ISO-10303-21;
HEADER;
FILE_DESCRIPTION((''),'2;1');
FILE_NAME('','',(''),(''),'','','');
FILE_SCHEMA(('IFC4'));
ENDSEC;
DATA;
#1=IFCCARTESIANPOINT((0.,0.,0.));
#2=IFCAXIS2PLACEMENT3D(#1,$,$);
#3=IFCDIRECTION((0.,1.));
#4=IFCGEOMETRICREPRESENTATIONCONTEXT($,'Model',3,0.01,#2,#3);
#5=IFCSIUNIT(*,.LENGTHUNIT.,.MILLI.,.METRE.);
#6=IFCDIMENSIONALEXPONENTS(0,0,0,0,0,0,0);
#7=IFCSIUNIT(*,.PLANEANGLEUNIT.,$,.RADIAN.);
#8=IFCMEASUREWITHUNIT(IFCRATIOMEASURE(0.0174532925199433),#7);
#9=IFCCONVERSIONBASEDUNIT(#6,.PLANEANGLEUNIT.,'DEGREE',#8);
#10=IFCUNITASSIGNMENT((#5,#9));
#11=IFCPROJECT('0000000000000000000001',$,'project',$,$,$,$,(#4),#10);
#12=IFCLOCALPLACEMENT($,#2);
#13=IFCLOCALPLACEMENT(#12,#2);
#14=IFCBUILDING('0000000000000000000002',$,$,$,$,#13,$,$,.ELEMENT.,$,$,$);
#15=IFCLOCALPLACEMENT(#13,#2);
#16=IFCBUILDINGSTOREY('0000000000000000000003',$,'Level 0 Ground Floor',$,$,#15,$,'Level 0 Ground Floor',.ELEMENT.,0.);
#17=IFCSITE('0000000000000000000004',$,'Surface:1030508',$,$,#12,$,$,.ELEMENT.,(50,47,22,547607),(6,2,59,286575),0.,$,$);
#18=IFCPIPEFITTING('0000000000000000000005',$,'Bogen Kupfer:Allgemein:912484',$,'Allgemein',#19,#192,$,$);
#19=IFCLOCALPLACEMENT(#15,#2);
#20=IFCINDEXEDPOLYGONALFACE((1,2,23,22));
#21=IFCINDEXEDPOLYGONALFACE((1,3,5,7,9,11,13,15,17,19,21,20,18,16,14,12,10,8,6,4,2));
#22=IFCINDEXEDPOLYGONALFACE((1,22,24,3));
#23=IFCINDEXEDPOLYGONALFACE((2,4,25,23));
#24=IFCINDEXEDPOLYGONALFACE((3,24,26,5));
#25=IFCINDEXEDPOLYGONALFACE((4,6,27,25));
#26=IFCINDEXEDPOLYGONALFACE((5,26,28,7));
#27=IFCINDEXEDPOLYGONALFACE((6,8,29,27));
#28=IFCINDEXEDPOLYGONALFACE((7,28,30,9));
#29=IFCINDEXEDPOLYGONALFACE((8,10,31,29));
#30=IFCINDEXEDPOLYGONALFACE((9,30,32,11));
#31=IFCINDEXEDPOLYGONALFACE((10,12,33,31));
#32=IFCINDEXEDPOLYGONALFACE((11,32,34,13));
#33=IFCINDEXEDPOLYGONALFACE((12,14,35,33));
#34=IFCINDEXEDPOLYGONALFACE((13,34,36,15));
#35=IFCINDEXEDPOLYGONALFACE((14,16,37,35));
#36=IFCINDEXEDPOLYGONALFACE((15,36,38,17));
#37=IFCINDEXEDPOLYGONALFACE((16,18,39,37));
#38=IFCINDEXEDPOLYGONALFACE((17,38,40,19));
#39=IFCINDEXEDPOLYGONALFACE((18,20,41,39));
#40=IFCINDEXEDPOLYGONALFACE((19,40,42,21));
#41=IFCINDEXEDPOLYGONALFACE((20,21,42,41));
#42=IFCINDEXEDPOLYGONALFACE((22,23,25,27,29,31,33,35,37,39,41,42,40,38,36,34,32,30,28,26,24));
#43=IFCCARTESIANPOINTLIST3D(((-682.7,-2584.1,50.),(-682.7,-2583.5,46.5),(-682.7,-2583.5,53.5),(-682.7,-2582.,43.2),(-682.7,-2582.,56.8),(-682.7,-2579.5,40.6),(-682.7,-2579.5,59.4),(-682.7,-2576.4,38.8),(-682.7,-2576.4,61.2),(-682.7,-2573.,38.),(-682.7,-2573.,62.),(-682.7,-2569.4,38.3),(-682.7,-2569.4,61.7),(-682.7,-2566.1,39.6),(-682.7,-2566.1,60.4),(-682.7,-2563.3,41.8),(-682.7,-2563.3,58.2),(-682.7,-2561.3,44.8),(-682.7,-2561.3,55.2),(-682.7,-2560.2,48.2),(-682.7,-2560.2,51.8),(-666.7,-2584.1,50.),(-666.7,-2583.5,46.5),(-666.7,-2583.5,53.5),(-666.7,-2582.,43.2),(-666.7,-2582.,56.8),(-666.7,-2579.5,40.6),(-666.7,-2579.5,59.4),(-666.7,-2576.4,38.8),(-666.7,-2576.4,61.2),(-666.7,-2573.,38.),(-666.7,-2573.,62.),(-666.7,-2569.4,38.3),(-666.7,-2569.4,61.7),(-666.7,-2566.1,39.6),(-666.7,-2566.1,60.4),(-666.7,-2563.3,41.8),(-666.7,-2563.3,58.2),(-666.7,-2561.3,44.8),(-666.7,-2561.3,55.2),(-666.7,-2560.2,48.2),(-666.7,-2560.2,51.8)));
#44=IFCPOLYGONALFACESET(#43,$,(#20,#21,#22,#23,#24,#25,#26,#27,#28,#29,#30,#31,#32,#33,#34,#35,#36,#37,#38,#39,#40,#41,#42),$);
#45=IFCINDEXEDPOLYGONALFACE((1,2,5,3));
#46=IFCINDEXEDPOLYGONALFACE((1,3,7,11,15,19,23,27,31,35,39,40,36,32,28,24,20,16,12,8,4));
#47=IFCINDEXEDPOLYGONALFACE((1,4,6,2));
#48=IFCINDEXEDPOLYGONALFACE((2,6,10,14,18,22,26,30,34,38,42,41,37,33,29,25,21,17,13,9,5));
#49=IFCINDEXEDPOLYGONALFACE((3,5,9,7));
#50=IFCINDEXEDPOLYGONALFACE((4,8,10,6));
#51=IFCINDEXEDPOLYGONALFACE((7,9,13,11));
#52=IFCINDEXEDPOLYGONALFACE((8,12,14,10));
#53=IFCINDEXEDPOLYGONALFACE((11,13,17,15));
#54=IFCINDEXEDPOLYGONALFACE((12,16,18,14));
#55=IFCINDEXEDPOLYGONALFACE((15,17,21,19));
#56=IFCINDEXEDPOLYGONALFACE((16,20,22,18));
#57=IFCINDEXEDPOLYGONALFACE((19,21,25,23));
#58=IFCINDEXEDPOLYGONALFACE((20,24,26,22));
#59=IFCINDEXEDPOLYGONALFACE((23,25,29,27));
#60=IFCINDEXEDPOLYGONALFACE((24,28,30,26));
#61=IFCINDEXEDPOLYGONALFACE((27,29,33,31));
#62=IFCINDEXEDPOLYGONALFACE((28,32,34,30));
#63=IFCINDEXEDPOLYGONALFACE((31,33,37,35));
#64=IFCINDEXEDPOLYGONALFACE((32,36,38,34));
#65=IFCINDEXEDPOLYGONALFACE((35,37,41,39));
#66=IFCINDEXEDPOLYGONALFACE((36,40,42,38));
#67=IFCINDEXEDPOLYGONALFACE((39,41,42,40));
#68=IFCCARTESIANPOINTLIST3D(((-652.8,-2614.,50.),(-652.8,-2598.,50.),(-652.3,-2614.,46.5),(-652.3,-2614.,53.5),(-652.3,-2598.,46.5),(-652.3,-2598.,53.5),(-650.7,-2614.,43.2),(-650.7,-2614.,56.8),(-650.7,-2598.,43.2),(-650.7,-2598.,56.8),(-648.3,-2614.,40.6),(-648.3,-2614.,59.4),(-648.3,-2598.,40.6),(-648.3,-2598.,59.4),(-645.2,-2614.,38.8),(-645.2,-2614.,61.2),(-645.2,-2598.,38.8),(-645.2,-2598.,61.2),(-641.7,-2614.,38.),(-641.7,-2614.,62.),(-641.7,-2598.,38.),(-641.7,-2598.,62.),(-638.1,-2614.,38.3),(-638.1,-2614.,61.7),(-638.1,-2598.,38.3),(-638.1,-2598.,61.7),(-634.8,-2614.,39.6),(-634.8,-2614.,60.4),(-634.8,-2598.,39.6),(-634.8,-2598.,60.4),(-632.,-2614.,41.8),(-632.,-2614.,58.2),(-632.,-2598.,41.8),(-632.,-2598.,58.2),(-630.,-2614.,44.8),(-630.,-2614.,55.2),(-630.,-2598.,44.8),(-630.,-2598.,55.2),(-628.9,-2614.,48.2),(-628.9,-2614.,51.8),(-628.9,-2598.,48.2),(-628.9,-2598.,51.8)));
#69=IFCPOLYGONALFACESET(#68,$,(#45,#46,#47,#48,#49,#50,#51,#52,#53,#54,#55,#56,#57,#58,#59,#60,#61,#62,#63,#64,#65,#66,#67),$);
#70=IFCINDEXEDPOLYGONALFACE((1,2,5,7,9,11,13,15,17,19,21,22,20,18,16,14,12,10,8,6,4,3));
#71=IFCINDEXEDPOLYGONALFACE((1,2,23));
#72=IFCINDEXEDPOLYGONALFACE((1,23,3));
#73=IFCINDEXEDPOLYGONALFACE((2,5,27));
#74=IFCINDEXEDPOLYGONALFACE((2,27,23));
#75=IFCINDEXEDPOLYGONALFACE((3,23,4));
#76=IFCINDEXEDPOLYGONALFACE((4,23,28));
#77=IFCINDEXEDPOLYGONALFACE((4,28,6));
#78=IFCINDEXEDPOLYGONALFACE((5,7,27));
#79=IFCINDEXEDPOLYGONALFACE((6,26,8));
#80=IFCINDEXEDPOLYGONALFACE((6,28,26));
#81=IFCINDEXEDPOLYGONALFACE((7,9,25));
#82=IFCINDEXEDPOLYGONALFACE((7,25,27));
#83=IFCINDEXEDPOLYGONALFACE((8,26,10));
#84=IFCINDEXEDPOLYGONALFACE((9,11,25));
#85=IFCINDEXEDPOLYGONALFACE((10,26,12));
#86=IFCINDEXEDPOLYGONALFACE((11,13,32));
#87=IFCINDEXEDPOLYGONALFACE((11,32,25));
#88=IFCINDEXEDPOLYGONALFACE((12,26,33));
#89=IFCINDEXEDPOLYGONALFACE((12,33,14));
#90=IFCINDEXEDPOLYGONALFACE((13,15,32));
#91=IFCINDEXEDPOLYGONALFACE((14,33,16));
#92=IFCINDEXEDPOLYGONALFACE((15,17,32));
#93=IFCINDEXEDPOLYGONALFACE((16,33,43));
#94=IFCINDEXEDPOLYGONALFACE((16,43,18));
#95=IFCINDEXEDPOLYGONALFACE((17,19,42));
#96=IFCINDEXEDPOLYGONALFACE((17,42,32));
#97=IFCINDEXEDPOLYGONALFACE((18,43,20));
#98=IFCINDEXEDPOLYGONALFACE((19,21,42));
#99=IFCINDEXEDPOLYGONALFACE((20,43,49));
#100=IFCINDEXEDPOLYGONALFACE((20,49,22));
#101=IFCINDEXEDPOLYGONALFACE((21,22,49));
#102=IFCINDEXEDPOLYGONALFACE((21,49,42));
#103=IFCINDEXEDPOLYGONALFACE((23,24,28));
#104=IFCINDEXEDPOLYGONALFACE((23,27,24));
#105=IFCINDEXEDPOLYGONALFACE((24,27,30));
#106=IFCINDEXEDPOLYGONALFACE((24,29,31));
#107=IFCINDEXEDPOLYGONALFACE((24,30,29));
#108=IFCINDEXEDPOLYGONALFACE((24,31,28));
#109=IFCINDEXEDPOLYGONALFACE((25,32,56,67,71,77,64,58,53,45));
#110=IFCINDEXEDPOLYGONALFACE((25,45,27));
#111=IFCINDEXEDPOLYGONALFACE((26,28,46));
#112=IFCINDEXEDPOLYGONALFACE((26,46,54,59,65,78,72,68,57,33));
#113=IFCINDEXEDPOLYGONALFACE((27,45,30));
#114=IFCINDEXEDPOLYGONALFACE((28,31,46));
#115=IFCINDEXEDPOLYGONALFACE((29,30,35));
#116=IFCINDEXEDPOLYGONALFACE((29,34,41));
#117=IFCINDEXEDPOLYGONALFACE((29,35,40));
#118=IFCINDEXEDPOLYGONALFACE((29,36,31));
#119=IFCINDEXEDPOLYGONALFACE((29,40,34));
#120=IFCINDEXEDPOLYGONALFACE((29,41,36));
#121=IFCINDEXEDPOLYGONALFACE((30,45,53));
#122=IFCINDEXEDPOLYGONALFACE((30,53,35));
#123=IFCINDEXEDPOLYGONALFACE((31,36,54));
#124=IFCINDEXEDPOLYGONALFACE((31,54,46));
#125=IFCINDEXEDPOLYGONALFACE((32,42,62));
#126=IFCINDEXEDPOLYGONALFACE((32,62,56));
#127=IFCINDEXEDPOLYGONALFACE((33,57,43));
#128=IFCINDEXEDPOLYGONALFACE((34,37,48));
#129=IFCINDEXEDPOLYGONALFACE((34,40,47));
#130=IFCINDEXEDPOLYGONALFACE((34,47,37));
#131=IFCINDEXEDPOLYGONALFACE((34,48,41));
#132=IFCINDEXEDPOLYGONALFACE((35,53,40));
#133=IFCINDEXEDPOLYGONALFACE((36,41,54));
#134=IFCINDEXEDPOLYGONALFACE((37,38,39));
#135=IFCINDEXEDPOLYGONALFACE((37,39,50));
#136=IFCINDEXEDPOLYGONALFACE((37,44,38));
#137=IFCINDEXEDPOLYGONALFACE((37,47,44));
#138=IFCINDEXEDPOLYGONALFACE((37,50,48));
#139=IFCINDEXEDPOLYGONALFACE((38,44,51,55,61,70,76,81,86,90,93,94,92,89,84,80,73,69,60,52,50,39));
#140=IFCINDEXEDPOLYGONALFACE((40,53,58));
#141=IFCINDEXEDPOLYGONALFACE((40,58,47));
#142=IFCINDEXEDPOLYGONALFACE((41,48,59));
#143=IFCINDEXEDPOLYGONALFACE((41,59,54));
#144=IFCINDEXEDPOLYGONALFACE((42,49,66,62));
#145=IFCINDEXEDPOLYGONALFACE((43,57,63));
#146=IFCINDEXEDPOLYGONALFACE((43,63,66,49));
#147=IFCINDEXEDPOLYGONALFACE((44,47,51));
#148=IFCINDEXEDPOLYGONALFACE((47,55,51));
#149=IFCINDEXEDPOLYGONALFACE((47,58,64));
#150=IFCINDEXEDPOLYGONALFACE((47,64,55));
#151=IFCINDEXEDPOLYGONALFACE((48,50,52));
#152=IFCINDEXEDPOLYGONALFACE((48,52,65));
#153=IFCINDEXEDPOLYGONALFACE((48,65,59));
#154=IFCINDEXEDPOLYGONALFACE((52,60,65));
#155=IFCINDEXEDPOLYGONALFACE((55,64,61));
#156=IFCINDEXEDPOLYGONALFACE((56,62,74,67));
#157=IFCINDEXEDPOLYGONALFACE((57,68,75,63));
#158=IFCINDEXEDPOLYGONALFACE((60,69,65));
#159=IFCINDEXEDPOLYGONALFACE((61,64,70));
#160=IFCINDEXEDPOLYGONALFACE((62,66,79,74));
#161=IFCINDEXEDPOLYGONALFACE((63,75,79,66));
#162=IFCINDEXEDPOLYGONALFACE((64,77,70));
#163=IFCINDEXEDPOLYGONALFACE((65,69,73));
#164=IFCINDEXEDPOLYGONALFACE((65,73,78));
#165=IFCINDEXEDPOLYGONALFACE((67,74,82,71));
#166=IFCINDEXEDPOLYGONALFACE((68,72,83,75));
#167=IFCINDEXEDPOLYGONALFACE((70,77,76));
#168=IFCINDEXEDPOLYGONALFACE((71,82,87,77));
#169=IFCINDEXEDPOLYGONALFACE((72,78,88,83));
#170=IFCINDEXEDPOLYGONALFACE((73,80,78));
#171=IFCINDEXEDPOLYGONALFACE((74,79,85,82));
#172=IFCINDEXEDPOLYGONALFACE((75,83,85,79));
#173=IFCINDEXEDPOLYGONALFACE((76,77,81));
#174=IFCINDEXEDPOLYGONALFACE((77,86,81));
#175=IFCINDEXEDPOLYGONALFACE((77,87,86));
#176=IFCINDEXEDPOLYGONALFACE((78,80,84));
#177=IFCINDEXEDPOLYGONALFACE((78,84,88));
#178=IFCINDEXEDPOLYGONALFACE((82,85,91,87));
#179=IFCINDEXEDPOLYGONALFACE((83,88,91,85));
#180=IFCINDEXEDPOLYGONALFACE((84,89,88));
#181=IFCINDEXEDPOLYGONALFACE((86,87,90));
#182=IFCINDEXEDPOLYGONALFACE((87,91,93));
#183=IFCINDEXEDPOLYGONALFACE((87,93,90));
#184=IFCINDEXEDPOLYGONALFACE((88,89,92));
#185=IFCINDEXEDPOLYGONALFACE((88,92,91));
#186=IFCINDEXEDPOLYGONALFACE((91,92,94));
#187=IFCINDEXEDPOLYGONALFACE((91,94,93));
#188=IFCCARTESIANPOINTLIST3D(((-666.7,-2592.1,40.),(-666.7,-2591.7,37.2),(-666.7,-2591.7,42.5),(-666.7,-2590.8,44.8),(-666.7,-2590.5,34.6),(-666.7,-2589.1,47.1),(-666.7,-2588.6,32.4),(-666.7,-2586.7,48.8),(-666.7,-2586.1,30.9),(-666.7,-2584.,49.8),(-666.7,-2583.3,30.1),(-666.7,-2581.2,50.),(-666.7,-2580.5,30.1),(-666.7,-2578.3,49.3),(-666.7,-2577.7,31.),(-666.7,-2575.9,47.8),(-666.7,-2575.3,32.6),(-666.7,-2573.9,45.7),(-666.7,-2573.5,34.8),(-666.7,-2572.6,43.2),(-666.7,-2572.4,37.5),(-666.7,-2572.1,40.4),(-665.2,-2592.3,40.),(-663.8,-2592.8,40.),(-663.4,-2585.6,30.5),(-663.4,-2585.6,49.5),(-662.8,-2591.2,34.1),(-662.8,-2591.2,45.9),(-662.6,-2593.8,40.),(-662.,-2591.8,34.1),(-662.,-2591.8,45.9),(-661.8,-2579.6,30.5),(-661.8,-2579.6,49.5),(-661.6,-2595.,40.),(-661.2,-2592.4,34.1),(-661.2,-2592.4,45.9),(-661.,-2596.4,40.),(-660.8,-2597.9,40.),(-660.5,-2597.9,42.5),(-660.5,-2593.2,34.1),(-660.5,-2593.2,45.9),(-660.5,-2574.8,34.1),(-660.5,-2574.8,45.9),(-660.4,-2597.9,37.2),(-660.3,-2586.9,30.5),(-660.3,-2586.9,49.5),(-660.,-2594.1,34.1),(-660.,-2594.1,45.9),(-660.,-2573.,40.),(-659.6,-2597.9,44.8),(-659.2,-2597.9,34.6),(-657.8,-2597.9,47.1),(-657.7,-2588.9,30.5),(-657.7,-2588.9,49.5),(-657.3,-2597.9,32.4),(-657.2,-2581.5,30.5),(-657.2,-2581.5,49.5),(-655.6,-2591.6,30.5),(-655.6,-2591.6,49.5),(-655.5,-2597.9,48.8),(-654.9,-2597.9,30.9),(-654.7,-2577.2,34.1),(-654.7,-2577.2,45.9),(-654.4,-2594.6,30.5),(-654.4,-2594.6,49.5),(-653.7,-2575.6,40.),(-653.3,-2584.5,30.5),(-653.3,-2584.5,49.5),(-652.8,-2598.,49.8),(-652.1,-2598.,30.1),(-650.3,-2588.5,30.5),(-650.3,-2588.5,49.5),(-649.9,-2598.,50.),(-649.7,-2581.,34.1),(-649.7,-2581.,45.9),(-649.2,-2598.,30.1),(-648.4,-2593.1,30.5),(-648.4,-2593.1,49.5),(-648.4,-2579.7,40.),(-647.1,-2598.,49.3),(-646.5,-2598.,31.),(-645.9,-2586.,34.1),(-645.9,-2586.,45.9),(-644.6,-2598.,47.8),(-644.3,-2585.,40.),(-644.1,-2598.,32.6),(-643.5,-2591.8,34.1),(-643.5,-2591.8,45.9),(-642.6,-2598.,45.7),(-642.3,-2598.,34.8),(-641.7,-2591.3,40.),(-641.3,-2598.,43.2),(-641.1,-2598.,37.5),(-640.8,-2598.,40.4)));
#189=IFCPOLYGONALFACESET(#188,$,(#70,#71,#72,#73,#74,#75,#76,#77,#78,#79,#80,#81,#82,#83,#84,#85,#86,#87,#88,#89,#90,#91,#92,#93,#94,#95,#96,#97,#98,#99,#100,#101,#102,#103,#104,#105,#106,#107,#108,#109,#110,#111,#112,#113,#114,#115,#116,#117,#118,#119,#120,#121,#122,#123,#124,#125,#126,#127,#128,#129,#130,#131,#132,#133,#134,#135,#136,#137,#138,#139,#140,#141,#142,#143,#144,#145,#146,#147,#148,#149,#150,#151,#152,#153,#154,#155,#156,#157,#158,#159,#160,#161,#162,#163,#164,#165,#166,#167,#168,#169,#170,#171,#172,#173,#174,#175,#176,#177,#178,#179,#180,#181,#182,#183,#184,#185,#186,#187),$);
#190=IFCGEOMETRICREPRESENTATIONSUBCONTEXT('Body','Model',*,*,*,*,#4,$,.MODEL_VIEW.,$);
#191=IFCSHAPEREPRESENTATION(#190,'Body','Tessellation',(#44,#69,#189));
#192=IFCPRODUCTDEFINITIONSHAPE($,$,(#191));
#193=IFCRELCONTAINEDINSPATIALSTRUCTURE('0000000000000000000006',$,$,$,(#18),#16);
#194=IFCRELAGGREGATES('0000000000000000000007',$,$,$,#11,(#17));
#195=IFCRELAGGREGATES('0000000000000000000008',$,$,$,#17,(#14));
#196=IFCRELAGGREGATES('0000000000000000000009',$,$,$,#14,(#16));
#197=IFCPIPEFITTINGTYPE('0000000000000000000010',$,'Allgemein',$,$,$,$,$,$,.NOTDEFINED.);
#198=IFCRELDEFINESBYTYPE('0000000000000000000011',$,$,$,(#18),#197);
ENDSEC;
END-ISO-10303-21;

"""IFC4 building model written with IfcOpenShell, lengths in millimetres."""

from ifc_helpers import new_model, entity, si_unit, converted_unit, direction, frame, frame_2d, origin, place, context, subcontext, project, spatial, circle, extrude, source, transform, mapped, type_object, type_shapes, element, save


model = new_model("IFC4")

# Units and contexts
model_context = context("Model", 3, precision=0.01, world=origin(), true_north=direction((0.0, 1.0)))
body_context = subcontext(model_context, "Body", "Model", "MODEL_VIEW")
ifc_project = project(units=[si_unit("LENGTHUNIT", "METRE", prefix="MILLI"), converted_unit("PLANEANGLEUNIT", "DEGREE", entity("IfcRatioMeasure", 0.0174532925199433), si_unit("PLANEANGLEUNIT", "RADIAN"), dimensions=[0, 0, 0, 0, 0, 0, 0])], contexts=[model_context])

# Site, building, storey
site_placement = place(None, origin())
site = spatial("IfcSite", under=ifc_project, at=site_placement, Name="Surface:1030508", CompositionType="ELEMENT", RefLatitude=(50, 47, 22, 547607), RefLongitude=(6, 2, 59, 286575), RefElevation=0.0)
building_placement = place(site_placement, origin())
building = spatial("IfcBuilding", under=site, at=building_placement, CompositionType="ELEMENT")
storey_placement = place(building_placement, origin())
storey = spatial("IfcBuildingStorey", under=building, at=storey_placement, Name="Level 0 Ground Floor", LongName="Level 0 Ground Floor", CompositionType="ELEMENT", Elevation=0.0)

# Pipe fitting
pipe_fitting_type_1 = type_object("IfcPipeFittingType", Name="Allgemein", PredefinedType="NOTDEFINED")
ifc_direction_1 = entity("IfcDirection", [0.0, 0.0, -1.0])
trimmed_curve_1 = entity("IfcTrimmedCurve", entity("IfcCircle", entity("IfcAxis2Placement2D", entity("IfcCartesianPoint", [-15.9, 0.0]), entity("IfcDirection", [-0.000001, 1.0])), 15.9), [entity("IfcParameterValue", 269.999931)], [entity("IfcParameterValue", 0.0)], True, "PARAMETER")
shared_shape_1 = source(origin(), body_context, "Body", "SolidModel", [
    extrude(circle(Radius=12.0, at=frame_2d((0.0, 0.0), x_axis=(1.0, 0.0))), frame((0.0, 41.9, 0.0), z_axis=(0.000001, -1.0, 0.0), x_axis=(-1.0, -0.000001, 0.0)), (0.0, 0.0, 1.0), 16.0),
    extrude(circle(Radius=12.0, at=frame_2d((0.0, 0.0), x_axis=(1.0, 0.0))), frame((-41.9, 0.0, 0.0), z_axis=(1.0, 0.0, 0.0), x_axis=(0.0, 1.0, 0.0)), (0.0, 0.0, 1.0), 16.0),
    entity("IfcSurfaceCurveSweptAreaSolid", entity("IfcCircleProfileDef", "AREA", None, entity("IfcAxis2Placement2D", entity("IfcCartesianPoint", [0.0, 10.0]), entity("IfcDirection", [1.0, 0.0])), 10.0), entity("IfcAxis2Placement3D", entity("IfcCartesianPoint", [-10.0, 25.9, 0.0]), ifc_direction_1, entity("IfcDirection", [1.0, 0.000001, 0.0])), trimmed_curve_1, 0.0, 90.0, entity("IfcSurfaceOfLinearExtrusion", entity("IfcArbitraryOpenProfileDef", "CURVE", None, trimmed_curve_1), entity("IfcAxis2Placement3D", entity("IfcCartesianPoint", [0.0, 0.0, -304.8])), ifc_direction_1, 1.0)),
])
type_shapes(pipe_fitting_type_1, [shared_shape_1])
pipe_fitting_1_placement = place(storey_placement, frame((-640.8, -2572.1, 50.0), z_axis=(0.0, 0.0, 1.0), x_axis=(0.0, 1.0, 0.0)))
element("IfcPipeFitting", 1, at=pipe_fitting_1_placement, inside=storey, type_object=pipe_fitting_type_1, Name="Bogen Kupfer:Allgemein:912484", ObjectType="Allgemein", context=body_context, shape_type="MappedRepresentation", body=[
    mapped(shared_shape_1, transform((0.0, 0.0, 0.0), scale=1.0)),
])

save(model, "model.ifc")
